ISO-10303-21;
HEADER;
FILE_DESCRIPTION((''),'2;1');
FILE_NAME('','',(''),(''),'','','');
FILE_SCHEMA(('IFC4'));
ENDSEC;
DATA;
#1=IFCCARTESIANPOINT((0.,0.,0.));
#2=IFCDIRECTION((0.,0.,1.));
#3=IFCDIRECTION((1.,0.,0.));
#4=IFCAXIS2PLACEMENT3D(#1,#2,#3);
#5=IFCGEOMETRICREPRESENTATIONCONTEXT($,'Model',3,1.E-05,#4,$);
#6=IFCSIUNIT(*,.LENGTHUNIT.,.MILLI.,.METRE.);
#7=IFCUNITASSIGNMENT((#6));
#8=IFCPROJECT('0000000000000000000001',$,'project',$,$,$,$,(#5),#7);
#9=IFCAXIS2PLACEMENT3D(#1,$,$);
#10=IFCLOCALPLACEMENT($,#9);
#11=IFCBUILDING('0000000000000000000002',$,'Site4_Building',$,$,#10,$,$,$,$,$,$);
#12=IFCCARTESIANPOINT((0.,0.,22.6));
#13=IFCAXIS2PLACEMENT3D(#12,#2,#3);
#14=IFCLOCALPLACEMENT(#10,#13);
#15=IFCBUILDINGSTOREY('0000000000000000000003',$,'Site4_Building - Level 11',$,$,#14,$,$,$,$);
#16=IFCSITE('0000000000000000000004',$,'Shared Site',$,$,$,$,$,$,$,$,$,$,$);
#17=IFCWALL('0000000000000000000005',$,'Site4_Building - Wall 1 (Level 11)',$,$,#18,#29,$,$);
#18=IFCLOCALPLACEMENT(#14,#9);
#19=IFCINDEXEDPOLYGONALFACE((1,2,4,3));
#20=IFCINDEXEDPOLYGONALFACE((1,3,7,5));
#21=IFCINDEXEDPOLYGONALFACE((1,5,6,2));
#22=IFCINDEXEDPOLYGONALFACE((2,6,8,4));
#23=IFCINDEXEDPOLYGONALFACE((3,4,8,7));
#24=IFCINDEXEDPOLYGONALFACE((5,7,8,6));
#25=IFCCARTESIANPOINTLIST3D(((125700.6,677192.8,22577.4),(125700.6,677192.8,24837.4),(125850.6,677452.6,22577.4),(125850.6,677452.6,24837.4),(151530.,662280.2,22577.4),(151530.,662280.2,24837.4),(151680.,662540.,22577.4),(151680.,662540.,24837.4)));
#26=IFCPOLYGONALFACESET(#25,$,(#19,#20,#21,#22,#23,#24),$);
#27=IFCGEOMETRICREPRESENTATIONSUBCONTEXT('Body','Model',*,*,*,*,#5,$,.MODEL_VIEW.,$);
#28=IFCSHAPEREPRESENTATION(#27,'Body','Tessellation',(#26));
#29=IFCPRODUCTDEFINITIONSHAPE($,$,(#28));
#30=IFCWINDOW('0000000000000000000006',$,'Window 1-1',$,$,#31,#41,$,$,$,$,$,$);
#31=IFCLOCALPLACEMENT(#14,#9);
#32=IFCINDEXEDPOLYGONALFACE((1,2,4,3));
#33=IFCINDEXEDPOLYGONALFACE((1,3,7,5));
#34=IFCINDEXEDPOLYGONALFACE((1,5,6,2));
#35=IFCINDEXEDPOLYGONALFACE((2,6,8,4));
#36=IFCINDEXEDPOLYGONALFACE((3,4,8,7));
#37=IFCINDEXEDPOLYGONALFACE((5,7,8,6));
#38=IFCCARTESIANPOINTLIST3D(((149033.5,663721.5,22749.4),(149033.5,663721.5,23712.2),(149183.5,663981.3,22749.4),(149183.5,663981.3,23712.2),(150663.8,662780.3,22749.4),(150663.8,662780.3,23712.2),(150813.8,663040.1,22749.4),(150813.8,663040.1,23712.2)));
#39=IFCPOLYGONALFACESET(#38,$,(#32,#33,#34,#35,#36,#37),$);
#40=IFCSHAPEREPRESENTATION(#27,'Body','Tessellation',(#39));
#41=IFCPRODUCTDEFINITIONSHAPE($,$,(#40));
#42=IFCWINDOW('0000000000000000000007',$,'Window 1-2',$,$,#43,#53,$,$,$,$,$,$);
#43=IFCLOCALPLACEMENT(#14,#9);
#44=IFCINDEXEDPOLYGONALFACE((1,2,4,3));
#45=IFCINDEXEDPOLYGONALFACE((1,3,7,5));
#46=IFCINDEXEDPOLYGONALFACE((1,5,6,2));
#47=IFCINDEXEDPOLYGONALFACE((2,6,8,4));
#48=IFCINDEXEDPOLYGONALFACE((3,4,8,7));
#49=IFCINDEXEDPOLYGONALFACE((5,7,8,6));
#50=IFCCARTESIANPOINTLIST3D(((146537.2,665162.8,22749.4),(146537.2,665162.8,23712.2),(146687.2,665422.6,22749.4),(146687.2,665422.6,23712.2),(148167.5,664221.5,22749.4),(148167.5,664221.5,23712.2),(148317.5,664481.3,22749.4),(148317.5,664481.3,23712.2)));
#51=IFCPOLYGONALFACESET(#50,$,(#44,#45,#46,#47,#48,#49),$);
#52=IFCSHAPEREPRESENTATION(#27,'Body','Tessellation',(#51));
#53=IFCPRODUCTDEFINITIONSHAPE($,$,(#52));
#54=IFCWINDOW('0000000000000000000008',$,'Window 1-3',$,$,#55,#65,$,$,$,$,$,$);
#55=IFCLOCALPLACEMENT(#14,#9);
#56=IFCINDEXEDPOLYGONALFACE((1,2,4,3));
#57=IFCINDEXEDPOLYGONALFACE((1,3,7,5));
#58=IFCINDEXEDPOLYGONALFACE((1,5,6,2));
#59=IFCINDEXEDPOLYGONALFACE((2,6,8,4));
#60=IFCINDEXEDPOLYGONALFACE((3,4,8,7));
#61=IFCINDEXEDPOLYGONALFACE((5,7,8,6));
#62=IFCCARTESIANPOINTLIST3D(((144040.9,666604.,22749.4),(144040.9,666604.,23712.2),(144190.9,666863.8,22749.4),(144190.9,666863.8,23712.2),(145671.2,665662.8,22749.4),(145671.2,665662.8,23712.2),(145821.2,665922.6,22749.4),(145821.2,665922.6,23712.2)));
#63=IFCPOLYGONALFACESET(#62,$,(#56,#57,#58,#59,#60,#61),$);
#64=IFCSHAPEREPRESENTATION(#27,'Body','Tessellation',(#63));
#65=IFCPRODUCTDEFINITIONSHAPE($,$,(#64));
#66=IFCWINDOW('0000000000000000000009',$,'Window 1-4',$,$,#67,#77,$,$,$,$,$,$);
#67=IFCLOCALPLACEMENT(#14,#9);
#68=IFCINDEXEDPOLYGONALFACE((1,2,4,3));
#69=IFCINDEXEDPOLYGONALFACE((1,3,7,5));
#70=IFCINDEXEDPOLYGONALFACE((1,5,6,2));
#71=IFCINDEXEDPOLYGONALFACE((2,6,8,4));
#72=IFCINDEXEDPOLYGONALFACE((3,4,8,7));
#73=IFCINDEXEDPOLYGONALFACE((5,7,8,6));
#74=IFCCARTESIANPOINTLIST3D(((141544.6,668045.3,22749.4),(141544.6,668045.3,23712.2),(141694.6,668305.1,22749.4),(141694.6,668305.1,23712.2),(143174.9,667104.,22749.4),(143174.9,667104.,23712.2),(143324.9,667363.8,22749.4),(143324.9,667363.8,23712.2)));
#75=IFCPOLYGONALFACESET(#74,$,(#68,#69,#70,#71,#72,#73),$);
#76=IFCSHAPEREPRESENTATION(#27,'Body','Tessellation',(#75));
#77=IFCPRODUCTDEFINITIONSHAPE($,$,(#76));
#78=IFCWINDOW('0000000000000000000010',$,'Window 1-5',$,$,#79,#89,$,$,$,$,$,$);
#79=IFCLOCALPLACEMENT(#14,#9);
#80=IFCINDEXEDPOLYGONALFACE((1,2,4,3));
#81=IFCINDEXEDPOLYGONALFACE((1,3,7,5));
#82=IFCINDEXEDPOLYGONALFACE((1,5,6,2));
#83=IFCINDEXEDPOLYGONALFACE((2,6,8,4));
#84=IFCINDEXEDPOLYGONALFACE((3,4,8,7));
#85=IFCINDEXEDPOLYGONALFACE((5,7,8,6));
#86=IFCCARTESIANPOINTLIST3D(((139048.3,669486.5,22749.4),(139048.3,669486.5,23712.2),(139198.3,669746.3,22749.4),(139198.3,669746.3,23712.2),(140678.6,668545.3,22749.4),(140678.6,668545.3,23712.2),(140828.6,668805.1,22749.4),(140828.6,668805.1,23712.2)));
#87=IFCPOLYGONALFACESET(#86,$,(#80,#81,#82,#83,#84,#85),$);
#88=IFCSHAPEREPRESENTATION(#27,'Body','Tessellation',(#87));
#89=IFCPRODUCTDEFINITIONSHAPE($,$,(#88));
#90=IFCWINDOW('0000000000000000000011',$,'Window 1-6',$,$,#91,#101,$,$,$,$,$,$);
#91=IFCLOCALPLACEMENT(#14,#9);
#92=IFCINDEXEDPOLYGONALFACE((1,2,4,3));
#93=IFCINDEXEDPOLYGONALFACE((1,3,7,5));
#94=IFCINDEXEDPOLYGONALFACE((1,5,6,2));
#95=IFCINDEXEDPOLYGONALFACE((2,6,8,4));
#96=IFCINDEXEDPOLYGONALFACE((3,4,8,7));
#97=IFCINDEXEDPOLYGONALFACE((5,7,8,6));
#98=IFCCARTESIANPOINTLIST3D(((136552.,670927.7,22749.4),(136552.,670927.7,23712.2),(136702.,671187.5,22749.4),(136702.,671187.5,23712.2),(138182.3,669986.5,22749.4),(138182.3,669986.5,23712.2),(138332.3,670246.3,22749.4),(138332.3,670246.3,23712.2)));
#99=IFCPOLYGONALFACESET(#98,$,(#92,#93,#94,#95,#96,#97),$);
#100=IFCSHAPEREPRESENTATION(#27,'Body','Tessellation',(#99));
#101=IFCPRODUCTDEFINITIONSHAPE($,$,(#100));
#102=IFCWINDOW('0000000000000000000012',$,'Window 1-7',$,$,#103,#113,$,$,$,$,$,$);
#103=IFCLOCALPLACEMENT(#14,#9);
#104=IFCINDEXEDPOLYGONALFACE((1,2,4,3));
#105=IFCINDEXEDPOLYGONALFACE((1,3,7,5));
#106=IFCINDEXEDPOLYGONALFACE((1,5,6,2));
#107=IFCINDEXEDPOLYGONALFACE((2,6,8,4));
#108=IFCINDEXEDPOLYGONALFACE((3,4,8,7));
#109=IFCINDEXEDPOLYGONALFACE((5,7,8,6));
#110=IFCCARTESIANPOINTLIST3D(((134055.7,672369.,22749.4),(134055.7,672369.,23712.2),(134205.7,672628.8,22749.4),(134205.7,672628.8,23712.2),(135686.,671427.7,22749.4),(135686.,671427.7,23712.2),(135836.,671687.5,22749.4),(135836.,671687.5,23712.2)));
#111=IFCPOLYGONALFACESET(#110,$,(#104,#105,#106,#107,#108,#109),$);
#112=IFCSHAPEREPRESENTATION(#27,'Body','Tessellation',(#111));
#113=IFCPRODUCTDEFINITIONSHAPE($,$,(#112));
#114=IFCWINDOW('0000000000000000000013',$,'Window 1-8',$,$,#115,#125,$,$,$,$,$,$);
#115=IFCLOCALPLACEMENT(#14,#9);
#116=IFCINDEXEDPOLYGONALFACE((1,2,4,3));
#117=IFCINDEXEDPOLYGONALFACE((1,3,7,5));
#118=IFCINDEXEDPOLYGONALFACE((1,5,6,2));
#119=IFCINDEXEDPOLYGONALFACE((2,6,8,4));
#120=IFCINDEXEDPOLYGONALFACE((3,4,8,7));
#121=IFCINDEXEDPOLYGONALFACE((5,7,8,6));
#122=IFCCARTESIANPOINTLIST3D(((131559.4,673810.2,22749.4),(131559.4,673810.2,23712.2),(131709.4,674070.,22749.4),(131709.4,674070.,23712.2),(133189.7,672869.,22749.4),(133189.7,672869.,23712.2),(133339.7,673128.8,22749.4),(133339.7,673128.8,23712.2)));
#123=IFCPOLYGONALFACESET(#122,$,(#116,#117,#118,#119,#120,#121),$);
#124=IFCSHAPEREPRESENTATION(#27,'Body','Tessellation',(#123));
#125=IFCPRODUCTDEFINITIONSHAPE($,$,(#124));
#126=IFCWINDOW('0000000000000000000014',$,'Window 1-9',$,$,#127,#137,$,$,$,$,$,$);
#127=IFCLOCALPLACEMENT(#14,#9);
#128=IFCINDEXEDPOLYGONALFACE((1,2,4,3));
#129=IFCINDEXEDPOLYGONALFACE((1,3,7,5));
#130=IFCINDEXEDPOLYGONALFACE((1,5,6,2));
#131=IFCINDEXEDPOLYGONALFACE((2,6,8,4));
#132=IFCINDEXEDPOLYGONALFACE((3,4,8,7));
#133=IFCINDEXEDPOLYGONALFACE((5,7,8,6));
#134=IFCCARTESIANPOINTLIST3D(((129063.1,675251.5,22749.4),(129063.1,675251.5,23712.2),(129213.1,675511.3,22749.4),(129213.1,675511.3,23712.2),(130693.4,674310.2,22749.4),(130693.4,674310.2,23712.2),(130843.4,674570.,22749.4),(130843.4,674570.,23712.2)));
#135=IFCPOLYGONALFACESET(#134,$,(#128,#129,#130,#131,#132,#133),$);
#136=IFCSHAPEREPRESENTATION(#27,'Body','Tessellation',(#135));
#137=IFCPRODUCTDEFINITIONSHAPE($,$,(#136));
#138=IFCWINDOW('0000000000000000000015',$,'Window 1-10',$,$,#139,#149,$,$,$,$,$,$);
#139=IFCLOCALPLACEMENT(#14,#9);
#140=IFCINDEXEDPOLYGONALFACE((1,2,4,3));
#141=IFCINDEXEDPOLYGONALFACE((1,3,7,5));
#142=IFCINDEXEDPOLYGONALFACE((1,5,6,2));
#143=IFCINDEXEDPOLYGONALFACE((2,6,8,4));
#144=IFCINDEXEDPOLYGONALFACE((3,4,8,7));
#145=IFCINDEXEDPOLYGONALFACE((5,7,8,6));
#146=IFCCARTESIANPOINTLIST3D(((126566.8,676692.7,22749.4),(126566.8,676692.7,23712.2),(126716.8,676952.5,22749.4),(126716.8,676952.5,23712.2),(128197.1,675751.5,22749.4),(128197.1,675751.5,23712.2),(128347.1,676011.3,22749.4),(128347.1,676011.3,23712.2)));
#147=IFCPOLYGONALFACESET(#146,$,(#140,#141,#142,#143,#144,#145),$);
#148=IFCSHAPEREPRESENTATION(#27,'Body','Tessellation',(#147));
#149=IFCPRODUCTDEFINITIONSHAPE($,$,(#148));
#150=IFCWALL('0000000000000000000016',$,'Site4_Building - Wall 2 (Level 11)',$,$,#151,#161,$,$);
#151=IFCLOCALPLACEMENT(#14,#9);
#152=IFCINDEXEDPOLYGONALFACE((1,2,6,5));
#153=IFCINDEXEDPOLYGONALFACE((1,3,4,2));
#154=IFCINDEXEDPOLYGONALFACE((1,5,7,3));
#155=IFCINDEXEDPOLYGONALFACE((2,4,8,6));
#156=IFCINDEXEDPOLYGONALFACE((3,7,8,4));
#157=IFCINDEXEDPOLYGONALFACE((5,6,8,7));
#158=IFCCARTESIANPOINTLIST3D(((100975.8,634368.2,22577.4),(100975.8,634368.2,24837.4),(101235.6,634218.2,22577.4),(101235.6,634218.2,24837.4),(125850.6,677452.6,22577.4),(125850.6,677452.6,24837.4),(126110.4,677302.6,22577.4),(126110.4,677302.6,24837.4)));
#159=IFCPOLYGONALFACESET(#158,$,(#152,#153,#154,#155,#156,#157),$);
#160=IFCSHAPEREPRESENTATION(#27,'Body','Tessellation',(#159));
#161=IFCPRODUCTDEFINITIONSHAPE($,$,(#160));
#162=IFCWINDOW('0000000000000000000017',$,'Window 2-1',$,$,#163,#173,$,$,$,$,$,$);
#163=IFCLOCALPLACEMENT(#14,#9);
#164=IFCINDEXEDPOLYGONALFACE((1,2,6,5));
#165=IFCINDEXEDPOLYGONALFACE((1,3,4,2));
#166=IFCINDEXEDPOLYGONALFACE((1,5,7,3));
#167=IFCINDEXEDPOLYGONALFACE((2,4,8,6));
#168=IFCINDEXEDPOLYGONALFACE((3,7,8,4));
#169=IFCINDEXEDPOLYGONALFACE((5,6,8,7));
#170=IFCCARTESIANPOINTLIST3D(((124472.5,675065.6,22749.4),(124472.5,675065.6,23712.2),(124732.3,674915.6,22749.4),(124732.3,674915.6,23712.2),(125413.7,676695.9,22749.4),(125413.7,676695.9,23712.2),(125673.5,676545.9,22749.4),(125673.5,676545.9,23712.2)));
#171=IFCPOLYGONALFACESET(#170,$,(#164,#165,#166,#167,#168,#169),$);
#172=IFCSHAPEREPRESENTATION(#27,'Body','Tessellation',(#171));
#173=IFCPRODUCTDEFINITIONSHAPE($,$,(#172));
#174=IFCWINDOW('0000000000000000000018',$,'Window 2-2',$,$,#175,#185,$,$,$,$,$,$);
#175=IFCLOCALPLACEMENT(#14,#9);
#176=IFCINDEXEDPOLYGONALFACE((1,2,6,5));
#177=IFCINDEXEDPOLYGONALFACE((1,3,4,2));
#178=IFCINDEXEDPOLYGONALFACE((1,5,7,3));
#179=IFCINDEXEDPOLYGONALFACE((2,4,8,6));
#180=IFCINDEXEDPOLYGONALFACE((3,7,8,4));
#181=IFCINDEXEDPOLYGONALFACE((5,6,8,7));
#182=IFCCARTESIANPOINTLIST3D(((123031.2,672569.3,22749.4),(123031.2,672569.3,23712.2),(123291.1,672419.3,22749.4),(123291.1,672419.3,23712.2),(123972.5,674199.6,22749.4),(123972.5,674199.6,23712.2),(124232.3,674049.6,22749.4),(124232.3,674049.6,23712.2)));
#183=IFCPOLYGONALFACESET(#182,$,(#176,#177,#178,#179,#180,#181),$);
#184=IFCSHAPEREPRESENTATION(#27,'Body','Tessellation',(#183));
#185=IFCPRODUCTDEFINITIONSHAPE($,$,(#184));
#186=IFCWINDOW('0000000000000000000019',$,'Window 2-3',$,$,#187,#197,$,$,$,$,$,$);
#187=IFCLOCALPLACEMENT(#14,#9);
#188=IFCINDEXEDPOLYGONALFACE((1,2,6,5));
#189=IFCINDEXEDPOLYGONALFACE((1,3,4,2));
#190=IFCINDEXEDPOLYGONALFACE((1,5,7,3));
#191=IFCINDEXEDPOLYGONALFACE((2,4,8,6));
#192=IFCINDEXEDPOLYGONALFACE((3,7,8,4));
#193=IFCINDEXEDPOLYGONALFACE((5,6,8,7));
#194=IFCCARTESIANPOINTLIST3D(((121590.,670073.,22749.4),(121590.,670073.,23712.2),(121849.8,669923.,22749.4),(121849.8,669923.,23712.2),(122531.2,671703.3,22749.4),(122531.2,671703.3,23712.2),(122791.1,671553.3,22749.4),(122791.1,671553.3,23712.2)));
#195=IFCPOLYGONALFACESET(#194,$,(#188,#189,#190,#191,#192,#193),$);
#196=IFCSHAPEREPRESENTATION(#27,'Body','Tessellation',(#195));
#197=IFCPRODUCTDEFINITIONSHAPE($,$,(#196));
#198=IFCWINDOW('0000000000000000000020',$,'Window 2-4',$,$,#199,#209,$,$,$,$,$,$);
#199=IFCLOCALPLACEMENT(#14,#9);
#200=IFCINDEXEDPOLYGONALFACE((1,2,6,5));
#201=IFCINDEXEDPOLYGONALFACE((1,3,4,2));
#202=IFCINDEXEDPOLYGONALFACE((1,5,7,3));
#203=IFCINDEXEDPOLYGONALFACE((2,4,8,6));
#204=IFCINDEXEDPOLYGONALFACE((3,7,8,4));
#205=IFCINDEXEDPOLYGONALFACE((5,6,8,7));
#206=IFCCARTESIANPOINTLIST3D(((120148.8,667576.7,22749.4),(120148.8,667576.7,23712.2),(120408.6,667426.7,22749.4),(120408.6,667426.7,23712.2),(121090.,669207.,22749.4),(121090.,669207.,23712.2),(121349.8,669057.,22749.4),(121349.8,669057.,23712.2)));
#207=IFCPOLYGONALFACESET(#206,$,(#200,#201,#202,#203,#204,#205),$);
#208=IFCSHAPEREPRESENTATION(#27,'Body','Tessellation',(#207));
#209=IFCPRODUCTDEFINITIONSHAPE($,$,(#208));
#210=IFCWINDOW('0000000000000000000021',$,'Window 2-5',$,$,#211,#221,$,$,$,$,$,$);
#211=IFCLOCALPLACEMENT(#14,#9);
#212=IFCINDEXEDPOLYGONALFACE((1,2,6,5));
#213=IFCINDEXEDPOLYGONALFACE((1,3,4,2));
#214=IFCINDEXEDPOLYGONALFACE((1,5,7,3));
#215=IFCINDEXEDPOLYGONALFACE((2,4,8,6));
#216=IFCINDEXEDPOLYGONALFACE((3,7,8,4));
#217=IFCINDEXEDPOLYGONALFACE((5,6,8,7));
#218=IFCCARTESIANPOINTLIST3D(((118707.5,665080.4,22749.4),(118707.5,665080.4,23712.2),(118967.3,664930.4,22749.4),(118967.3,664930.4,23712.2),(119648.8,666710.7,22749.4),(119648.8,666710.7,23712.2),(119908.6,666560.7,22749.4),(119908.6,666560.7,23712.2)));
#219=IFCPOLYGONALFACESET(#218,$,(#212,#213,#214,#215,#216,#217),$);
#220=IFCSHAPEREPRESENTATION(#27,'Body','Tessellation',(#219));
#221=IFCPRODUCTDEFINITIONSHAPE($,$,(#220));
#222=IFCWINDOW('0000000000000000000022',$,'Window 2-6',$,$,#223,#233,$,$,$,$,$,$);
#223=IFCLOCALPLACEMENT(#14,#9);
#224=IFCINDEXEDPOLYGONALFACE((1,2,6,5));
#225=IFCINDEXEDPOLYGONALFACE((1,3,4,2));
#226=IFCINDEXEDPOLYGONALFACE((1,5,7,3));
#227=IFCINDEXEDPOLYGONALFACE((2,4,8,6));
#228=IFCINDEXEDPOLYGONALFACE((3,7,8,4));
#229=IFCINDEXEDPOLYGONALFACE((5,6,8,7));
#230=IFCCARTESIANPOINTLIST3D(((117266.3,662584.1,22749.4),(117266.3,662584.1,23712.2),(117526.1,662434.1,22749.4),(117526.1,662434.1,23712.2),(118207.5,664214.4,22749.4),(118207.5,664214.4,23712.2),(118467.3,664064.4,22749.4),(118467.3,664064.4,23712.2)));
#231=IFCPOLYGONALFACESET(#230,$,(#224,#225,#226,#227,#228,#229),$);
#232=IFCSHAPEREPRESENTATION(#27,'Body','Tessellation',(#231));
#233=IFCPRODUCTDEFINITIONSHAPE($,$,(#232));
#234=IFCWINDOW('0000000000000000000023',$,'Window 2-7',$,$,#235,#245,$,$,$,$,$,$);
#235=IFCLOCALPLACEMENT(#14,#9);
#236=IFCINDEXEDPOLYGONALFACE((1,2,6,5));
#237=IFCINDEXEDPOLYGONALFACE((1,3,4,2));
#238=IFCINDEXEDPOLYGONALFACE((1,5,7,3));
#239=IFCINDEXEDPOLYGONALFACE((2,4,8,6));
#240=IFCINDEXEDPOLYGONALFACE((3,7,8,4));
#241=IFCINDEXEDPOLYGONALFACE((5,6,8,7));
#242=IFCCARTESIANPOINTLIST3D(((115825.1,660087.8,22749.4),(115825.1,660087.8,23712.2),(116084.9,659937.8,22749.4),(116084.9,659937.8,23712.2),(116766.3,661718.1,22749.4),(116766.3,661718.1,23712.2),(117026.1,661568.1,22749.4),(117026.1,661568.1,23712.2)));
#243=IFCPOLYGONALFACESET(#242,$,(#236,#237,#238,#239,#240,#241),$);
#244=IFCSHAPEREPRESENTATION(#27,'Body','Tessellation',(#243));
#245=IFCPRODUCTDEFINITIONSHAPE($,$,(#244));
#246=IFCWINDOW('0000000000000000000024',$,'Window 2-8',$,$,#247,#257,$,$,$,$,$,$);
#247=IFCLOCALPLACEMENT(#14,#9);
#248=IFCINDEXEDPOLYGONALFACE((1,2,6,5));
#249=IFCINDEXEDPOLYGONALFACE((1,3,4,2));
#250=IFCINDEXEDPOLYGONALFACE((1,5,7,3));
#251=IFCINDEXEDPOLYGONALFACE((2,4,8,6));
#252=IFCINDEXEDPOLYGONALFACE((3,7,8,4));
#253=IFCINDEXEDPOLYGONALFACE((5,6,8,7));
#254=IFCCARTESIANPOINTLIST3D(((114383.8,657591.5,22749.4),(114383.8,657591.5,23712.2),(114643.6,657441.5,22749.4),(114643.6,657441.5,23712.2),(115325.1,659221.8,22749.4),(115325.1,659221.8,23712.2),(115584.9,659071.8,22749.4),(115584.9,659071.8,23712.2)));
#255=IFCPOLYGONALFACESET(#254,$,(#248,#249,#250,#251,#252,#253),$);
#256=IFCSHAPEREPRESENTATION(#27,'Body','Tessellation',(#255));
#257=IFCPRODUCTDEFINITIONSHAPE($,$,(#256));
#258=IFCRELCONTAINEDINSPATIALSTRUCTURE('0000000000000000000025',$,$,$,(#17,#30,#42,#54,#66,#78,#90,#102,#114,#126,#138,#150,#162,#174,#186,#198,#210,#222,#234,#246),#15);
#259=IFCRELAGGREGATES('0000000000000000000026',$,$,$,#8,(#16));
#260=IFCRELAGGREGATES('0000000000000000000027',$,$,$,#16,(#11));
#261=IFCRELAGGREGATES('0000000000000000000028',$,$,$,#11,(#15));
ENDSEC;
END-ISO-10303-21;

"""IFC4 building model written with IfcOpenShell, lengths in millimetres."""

from ifc_helpers import new_model, si_unit, frame, origin, origin_with_axes, place, context, subcontext, project, spatial, indexed_curve, outline, extrude, element, save


model = new_model("IFC4")

# Units and contexts
model_context = context("Model", 3, precision=1e-05, world=origin_with_axes())
body_context = subcontext(model_context, "Body", "Model", "MODEL_VIEW")
ifc_project = project(units=[si_unit("LENGTHUNIT", "METRE", prefix="MILLI")], contexts=[model_context])

# Site, building, storey
site = spatial("IfcSite", under=ifc_project, Name="Shared Site")
building_placement = place(None, origin())
building = spatial("IfcBuilding", under=site, at=building_placement, Name="Site4_Building")
storey_placement = place(building_placement, frame((0.0, 0.0, 22.6), z_axis=(0.0, 0.0, 1.0), x_axis=(1.0, 0.0, 0.0)))
storey = spatial("IfcBuildingStorey", under=building, at=storey_placement, Name="Site4_Building - Level 11")

# Wall
wall_1_placement = place(storey_placement, frame((151680.0, 662540.0, 22577.4), z_axis=(0.0, 0.0, 1.0), x_axis=(-0.866025, 0.5, 0.0)))
element("IfcWall", 1, at=wall_1_placement, inside=storey, Name="Site4_Building - Wall 1 (Level 11)", context=body_context, shape_type="SweptSolid", body=[
    extrude(outline(indexed_curve([(0.0, 0.0), (0.0, 300.0), (29825.2, 300.0), (29825.2, 0.0), (0.0, 0.0)], self_intersect=False)), origin_with_axes(), (0.0, 0.0, 1.0), 2260.0),
])

# Windows
for number, where, z_axis, x_axis, name in (
    (2, (150813.8, 663040.1, 22749.4), (0.0, 0.0, 1.0), (-0.866025, 0.5, 0.0), "Window 1-1"),
    (3, (148317.5, 664481.3, 22749.4), (0.0, 0.0, 1.0), (-0.866025, 0.5, 0.0), "Window 1-2"),
    (4, (145821.2, 665922.6, 22749.4), (0.0, 0.0, 1.0), (-0.866025, 0.5, 0.0), "Window 1-3"),
    (5, (143324.9, 667363.8, 22749.4), (0.0, 0.0, 1.0), (-0.866025, 0.5, 0.0), "Window 1-4"),
    (6, (140828.6, 668805.1, 22749.4), (0.0, 0.0, 1.0), (-0.866025, 0.5, 0.0), "Window 1-5"),
    (7, (138332.3, 670246.3, 22749.4), (0.0, 0.0, 1.0), (-0.866025, 0.5, 0.0), "Window 1-6"),
    (8, (135836.0, 671687.5, 22749.4), (0.0, 0.0, 1.0), (-0.866025, 0.5, 0.0), "Window 1-7"),
    (9, (133339.7, 673128.8, 22749.4), (0.0, 0.0, 1.0), (-0.866025, 0.5, 0.0), "Window 1-8"),
    (10, (130843.4, 674570.0, 22749.4), (0.0, 0.0, 1.0), (-0.866025, 0.5, 0.0), "Window 1-9"),
    (11, (128347.1, 676011.3, 22749.4), (0.0, 0.0, 1.0), (-0.866025, 0.5, 0.0), "Window 1-10"),
):
    element("IfcWindow", number, at=place(storey_placement, frame(where, z_axis=z_axis, x_axis=x_axis)), inside=storey, Name=name, context=body_context, shape_type="SweptSolid", body=[
        extrude(outline(indexed_curve([(0.0, 0.0), (0.0, 300.0), (1882.5, 300.0), (1882.5, 0.0), (0.0, 0.0)], self_intersect=False)), origin_with_axes(), (0.0, 0.0, 1.0), 962.8),
    ])

# Wall
wall_2_placement = place(storey_placement, frame((125850.6, 677452.6, 22577.4), z_axis=(0.0, 0.0, 1.0), x_axis=(-0.5, -0.866025, 0.0)))
element("IfcWall", 12, at=wall_2_placement, inside=storey, Name="Site4_Building - Wall 2 (Level 11)", context=body_context, shape_type="SweptSolid", body=[
    extrude(outline(indexed_curve([(0.0, 0.0), (0.0, 300.0), (49749.6, 300.0), (49749.6, 0.0), (0.0, 0.0)], self_intersect=False)), origin_with_axes(), (0.0, 0.0, 1.0), 2260.0),
])

# Windows
for number, where, z_axis, x_axis, name in (
    (13, (125413.7, 676695.9, 22749.4), (0.0, 0.0, 1.0), (-0.5, -0.866025, 0.0), "Window 2-1"),
    (14, (123972.5, 674199.6, 22749.4), (0.0, 0.0, 1.0), (-0.5, -0.866025, 0.0), "Window 2-2"),
    (15, (122531.2, 671703.3, 22749.4), (0.0, 0.0, 1.0), (-0.5, -0.866025, 0.0), "Window 2-3"),
    (16, (121090.0, 669207.0, 22749.4), (0.0, 0.0, 1.0), (-0.5, -0.866025, 0.0), "Window 2-4"),
    (17, (119648.8, 666710.7, 22749.4), (0.0, 0.0, 1.0), (-0.5, -0.866025, 0.0), "Window 2-5"),
    (18, (118207.5, 664214.4, 22749.4), (0.0, 0.0, 1.0), (-0.5, -0.866025, 0.0), "Window 2-6"),
    (19, (116766.3, 661718.1, 22749.4), (0.0, 0.0, 1.0), (-0.5, -0.866025, 0.0), "Window 2-7"),
    (20, (115325.1, 659221.8, 22749.4), (0.0, 0.0, 1.0), (-0.5, -0.866025, 0.0), "Window 2-8"),
):
    element("IfcWindow", number, at=place(storey_placement, frame(where, z_axis=z_axis, x_axis=x_axis)), inside=storey, Name=name, context=body_context, shape_type="SweptSolid", body=[
        extrude(outline(indexed_curve([(0.0, 0.0), (0.0, 300.0), (1882.5, 300.0), (1882.5, 0.0), (0.0, 0.0)], self_intersect=False)), origin_with_axes(), (0.0, 0.0, 1.0), 962.8),
    ])

save(model, "model.ifc")
